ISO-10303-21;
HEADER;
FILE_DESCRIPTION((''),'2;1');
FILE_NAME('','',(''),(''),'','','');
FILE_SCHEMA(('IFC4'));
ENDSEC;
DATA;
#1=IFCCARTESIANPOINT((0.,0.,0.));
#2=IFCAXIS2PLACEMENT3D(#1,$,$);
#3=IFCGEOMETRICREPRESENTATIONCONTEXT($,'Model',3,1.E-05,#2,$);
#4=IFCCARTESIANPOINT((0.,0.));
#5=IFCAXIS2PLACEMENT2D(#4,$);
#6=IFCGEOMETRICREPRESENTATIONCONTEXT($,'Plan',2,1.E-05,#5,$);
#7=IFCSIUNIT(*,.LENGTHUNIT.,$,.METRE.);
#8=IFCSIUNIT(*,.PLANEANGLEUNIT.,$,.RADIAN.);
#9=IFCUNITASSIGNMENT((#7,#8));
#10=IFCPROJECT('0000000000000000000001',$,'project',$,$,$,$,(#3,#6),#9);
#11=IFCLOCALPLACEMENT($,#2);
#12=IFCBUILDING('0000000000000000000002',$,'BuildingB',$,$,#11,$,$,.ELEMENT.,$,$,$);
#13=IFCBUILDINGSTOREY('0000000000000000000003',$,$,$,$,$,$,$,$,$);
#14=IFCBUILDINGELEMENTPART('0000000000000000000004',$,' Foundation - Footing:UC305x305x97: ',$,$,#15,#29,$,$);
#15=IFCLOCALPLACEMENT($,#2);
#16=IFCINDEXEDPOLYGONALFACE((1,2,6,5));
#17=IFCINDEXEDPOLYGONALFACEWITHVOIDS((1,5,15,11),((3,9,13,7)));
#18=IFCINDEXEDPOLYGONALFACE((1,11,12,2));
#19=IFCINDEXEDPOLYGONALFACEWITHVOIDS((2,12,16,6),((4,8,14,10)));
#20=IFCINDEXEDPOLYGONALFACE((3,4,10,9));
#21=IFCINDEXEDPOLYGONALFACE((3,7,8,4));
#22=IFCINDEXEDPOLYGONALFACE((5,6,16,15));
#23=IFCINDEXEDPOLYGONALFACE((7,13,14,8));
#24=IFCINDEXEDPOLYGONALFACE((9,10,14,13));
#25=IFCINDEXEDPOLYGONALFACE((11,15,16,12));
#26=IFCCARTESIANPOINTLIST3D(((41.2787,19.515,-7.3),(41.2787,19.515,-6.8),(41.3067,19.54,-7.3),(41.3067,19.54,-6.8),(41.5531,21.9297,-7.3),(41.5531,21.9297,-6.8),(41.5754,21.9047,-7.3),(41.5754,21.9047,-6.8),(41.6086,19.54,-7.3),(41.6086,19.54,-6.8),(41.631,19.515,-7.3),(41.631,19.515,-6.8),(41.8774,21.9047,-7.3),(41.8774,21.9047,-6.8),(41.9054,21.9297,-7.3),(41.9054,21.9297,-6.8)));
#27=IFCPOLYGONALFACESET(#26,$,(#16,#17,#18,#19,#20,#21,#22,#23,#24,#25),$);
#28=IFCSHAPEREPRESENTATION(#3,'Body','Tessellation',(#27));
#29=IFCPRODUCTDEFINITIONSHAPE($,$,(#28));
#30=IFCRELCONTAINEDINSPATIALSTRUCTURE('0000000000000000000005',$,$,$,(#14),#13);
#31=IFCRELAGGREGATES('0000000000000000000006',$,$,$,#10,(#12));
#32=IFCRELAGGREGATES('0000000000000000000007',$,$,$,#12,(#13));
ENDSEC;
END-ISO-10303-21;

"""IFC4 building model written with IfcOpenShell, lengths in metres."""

from ifc_helpers import new_model, si_unit, origin, origin_2d, place, context, project, spatial, polyline, outline, extrude, element, save


model = new_model("IFC4")

# Units and contexts
model_context = context("Model", 3, precision=1e-05, world=origin())
plan_context = context("Plan", 2, precision=1e-05, world=origin_2d())
ifc_project = project(units=[si_unit("LENGTHUNIT", "METRE"), si_unit("PLANEANGLEUNIT", "RADIAN")], contexts=[model_context, plan_context])

# Building, storey
building_placement = place(None, origin())
building = spatial("IfcBuilding", under=ifc_project, at=building_placement, Name="BuildingB", CompositionType="ELEMENT")
storey = spatial("IfcBuildingStorey", under=building)

# Building element part, opening
building_element_part_1 = element("IfcBuildingElementPart", 1, inside=storey, Name=" Foundation - Footing:UC305x305x97: ", context=model_context, shape_type="SweptSolid", body=[
    extrude(outline(polyline([(41.2787, 19.515, -7.3), (41.631, 19.515, -7.3), (41.9054, 21.9297, -7.3), (41.5531, 21.9297, -7.3), (41.2787, 19.515, -7.3)])), None, (0.0, 0.0, 1.0), 0.5),
])
element("IfcOpeningElement", 2, inside=storey, cuts=building_element_part_1, context=model_context, shape_type="SweptSolid", body=[
    extrude(outline(polyline([(41.3067, 19.54, -7.3), (41.6086, 19.54, -7.3), (41.8774, 21.9047, -7.3), (41.5754, 21.9047, -7.3), (41.3067, 19.54, -7.3)])), None, (0.0, 0.0, 1.0), 0.5),
])

save(model, "model.ifc")
